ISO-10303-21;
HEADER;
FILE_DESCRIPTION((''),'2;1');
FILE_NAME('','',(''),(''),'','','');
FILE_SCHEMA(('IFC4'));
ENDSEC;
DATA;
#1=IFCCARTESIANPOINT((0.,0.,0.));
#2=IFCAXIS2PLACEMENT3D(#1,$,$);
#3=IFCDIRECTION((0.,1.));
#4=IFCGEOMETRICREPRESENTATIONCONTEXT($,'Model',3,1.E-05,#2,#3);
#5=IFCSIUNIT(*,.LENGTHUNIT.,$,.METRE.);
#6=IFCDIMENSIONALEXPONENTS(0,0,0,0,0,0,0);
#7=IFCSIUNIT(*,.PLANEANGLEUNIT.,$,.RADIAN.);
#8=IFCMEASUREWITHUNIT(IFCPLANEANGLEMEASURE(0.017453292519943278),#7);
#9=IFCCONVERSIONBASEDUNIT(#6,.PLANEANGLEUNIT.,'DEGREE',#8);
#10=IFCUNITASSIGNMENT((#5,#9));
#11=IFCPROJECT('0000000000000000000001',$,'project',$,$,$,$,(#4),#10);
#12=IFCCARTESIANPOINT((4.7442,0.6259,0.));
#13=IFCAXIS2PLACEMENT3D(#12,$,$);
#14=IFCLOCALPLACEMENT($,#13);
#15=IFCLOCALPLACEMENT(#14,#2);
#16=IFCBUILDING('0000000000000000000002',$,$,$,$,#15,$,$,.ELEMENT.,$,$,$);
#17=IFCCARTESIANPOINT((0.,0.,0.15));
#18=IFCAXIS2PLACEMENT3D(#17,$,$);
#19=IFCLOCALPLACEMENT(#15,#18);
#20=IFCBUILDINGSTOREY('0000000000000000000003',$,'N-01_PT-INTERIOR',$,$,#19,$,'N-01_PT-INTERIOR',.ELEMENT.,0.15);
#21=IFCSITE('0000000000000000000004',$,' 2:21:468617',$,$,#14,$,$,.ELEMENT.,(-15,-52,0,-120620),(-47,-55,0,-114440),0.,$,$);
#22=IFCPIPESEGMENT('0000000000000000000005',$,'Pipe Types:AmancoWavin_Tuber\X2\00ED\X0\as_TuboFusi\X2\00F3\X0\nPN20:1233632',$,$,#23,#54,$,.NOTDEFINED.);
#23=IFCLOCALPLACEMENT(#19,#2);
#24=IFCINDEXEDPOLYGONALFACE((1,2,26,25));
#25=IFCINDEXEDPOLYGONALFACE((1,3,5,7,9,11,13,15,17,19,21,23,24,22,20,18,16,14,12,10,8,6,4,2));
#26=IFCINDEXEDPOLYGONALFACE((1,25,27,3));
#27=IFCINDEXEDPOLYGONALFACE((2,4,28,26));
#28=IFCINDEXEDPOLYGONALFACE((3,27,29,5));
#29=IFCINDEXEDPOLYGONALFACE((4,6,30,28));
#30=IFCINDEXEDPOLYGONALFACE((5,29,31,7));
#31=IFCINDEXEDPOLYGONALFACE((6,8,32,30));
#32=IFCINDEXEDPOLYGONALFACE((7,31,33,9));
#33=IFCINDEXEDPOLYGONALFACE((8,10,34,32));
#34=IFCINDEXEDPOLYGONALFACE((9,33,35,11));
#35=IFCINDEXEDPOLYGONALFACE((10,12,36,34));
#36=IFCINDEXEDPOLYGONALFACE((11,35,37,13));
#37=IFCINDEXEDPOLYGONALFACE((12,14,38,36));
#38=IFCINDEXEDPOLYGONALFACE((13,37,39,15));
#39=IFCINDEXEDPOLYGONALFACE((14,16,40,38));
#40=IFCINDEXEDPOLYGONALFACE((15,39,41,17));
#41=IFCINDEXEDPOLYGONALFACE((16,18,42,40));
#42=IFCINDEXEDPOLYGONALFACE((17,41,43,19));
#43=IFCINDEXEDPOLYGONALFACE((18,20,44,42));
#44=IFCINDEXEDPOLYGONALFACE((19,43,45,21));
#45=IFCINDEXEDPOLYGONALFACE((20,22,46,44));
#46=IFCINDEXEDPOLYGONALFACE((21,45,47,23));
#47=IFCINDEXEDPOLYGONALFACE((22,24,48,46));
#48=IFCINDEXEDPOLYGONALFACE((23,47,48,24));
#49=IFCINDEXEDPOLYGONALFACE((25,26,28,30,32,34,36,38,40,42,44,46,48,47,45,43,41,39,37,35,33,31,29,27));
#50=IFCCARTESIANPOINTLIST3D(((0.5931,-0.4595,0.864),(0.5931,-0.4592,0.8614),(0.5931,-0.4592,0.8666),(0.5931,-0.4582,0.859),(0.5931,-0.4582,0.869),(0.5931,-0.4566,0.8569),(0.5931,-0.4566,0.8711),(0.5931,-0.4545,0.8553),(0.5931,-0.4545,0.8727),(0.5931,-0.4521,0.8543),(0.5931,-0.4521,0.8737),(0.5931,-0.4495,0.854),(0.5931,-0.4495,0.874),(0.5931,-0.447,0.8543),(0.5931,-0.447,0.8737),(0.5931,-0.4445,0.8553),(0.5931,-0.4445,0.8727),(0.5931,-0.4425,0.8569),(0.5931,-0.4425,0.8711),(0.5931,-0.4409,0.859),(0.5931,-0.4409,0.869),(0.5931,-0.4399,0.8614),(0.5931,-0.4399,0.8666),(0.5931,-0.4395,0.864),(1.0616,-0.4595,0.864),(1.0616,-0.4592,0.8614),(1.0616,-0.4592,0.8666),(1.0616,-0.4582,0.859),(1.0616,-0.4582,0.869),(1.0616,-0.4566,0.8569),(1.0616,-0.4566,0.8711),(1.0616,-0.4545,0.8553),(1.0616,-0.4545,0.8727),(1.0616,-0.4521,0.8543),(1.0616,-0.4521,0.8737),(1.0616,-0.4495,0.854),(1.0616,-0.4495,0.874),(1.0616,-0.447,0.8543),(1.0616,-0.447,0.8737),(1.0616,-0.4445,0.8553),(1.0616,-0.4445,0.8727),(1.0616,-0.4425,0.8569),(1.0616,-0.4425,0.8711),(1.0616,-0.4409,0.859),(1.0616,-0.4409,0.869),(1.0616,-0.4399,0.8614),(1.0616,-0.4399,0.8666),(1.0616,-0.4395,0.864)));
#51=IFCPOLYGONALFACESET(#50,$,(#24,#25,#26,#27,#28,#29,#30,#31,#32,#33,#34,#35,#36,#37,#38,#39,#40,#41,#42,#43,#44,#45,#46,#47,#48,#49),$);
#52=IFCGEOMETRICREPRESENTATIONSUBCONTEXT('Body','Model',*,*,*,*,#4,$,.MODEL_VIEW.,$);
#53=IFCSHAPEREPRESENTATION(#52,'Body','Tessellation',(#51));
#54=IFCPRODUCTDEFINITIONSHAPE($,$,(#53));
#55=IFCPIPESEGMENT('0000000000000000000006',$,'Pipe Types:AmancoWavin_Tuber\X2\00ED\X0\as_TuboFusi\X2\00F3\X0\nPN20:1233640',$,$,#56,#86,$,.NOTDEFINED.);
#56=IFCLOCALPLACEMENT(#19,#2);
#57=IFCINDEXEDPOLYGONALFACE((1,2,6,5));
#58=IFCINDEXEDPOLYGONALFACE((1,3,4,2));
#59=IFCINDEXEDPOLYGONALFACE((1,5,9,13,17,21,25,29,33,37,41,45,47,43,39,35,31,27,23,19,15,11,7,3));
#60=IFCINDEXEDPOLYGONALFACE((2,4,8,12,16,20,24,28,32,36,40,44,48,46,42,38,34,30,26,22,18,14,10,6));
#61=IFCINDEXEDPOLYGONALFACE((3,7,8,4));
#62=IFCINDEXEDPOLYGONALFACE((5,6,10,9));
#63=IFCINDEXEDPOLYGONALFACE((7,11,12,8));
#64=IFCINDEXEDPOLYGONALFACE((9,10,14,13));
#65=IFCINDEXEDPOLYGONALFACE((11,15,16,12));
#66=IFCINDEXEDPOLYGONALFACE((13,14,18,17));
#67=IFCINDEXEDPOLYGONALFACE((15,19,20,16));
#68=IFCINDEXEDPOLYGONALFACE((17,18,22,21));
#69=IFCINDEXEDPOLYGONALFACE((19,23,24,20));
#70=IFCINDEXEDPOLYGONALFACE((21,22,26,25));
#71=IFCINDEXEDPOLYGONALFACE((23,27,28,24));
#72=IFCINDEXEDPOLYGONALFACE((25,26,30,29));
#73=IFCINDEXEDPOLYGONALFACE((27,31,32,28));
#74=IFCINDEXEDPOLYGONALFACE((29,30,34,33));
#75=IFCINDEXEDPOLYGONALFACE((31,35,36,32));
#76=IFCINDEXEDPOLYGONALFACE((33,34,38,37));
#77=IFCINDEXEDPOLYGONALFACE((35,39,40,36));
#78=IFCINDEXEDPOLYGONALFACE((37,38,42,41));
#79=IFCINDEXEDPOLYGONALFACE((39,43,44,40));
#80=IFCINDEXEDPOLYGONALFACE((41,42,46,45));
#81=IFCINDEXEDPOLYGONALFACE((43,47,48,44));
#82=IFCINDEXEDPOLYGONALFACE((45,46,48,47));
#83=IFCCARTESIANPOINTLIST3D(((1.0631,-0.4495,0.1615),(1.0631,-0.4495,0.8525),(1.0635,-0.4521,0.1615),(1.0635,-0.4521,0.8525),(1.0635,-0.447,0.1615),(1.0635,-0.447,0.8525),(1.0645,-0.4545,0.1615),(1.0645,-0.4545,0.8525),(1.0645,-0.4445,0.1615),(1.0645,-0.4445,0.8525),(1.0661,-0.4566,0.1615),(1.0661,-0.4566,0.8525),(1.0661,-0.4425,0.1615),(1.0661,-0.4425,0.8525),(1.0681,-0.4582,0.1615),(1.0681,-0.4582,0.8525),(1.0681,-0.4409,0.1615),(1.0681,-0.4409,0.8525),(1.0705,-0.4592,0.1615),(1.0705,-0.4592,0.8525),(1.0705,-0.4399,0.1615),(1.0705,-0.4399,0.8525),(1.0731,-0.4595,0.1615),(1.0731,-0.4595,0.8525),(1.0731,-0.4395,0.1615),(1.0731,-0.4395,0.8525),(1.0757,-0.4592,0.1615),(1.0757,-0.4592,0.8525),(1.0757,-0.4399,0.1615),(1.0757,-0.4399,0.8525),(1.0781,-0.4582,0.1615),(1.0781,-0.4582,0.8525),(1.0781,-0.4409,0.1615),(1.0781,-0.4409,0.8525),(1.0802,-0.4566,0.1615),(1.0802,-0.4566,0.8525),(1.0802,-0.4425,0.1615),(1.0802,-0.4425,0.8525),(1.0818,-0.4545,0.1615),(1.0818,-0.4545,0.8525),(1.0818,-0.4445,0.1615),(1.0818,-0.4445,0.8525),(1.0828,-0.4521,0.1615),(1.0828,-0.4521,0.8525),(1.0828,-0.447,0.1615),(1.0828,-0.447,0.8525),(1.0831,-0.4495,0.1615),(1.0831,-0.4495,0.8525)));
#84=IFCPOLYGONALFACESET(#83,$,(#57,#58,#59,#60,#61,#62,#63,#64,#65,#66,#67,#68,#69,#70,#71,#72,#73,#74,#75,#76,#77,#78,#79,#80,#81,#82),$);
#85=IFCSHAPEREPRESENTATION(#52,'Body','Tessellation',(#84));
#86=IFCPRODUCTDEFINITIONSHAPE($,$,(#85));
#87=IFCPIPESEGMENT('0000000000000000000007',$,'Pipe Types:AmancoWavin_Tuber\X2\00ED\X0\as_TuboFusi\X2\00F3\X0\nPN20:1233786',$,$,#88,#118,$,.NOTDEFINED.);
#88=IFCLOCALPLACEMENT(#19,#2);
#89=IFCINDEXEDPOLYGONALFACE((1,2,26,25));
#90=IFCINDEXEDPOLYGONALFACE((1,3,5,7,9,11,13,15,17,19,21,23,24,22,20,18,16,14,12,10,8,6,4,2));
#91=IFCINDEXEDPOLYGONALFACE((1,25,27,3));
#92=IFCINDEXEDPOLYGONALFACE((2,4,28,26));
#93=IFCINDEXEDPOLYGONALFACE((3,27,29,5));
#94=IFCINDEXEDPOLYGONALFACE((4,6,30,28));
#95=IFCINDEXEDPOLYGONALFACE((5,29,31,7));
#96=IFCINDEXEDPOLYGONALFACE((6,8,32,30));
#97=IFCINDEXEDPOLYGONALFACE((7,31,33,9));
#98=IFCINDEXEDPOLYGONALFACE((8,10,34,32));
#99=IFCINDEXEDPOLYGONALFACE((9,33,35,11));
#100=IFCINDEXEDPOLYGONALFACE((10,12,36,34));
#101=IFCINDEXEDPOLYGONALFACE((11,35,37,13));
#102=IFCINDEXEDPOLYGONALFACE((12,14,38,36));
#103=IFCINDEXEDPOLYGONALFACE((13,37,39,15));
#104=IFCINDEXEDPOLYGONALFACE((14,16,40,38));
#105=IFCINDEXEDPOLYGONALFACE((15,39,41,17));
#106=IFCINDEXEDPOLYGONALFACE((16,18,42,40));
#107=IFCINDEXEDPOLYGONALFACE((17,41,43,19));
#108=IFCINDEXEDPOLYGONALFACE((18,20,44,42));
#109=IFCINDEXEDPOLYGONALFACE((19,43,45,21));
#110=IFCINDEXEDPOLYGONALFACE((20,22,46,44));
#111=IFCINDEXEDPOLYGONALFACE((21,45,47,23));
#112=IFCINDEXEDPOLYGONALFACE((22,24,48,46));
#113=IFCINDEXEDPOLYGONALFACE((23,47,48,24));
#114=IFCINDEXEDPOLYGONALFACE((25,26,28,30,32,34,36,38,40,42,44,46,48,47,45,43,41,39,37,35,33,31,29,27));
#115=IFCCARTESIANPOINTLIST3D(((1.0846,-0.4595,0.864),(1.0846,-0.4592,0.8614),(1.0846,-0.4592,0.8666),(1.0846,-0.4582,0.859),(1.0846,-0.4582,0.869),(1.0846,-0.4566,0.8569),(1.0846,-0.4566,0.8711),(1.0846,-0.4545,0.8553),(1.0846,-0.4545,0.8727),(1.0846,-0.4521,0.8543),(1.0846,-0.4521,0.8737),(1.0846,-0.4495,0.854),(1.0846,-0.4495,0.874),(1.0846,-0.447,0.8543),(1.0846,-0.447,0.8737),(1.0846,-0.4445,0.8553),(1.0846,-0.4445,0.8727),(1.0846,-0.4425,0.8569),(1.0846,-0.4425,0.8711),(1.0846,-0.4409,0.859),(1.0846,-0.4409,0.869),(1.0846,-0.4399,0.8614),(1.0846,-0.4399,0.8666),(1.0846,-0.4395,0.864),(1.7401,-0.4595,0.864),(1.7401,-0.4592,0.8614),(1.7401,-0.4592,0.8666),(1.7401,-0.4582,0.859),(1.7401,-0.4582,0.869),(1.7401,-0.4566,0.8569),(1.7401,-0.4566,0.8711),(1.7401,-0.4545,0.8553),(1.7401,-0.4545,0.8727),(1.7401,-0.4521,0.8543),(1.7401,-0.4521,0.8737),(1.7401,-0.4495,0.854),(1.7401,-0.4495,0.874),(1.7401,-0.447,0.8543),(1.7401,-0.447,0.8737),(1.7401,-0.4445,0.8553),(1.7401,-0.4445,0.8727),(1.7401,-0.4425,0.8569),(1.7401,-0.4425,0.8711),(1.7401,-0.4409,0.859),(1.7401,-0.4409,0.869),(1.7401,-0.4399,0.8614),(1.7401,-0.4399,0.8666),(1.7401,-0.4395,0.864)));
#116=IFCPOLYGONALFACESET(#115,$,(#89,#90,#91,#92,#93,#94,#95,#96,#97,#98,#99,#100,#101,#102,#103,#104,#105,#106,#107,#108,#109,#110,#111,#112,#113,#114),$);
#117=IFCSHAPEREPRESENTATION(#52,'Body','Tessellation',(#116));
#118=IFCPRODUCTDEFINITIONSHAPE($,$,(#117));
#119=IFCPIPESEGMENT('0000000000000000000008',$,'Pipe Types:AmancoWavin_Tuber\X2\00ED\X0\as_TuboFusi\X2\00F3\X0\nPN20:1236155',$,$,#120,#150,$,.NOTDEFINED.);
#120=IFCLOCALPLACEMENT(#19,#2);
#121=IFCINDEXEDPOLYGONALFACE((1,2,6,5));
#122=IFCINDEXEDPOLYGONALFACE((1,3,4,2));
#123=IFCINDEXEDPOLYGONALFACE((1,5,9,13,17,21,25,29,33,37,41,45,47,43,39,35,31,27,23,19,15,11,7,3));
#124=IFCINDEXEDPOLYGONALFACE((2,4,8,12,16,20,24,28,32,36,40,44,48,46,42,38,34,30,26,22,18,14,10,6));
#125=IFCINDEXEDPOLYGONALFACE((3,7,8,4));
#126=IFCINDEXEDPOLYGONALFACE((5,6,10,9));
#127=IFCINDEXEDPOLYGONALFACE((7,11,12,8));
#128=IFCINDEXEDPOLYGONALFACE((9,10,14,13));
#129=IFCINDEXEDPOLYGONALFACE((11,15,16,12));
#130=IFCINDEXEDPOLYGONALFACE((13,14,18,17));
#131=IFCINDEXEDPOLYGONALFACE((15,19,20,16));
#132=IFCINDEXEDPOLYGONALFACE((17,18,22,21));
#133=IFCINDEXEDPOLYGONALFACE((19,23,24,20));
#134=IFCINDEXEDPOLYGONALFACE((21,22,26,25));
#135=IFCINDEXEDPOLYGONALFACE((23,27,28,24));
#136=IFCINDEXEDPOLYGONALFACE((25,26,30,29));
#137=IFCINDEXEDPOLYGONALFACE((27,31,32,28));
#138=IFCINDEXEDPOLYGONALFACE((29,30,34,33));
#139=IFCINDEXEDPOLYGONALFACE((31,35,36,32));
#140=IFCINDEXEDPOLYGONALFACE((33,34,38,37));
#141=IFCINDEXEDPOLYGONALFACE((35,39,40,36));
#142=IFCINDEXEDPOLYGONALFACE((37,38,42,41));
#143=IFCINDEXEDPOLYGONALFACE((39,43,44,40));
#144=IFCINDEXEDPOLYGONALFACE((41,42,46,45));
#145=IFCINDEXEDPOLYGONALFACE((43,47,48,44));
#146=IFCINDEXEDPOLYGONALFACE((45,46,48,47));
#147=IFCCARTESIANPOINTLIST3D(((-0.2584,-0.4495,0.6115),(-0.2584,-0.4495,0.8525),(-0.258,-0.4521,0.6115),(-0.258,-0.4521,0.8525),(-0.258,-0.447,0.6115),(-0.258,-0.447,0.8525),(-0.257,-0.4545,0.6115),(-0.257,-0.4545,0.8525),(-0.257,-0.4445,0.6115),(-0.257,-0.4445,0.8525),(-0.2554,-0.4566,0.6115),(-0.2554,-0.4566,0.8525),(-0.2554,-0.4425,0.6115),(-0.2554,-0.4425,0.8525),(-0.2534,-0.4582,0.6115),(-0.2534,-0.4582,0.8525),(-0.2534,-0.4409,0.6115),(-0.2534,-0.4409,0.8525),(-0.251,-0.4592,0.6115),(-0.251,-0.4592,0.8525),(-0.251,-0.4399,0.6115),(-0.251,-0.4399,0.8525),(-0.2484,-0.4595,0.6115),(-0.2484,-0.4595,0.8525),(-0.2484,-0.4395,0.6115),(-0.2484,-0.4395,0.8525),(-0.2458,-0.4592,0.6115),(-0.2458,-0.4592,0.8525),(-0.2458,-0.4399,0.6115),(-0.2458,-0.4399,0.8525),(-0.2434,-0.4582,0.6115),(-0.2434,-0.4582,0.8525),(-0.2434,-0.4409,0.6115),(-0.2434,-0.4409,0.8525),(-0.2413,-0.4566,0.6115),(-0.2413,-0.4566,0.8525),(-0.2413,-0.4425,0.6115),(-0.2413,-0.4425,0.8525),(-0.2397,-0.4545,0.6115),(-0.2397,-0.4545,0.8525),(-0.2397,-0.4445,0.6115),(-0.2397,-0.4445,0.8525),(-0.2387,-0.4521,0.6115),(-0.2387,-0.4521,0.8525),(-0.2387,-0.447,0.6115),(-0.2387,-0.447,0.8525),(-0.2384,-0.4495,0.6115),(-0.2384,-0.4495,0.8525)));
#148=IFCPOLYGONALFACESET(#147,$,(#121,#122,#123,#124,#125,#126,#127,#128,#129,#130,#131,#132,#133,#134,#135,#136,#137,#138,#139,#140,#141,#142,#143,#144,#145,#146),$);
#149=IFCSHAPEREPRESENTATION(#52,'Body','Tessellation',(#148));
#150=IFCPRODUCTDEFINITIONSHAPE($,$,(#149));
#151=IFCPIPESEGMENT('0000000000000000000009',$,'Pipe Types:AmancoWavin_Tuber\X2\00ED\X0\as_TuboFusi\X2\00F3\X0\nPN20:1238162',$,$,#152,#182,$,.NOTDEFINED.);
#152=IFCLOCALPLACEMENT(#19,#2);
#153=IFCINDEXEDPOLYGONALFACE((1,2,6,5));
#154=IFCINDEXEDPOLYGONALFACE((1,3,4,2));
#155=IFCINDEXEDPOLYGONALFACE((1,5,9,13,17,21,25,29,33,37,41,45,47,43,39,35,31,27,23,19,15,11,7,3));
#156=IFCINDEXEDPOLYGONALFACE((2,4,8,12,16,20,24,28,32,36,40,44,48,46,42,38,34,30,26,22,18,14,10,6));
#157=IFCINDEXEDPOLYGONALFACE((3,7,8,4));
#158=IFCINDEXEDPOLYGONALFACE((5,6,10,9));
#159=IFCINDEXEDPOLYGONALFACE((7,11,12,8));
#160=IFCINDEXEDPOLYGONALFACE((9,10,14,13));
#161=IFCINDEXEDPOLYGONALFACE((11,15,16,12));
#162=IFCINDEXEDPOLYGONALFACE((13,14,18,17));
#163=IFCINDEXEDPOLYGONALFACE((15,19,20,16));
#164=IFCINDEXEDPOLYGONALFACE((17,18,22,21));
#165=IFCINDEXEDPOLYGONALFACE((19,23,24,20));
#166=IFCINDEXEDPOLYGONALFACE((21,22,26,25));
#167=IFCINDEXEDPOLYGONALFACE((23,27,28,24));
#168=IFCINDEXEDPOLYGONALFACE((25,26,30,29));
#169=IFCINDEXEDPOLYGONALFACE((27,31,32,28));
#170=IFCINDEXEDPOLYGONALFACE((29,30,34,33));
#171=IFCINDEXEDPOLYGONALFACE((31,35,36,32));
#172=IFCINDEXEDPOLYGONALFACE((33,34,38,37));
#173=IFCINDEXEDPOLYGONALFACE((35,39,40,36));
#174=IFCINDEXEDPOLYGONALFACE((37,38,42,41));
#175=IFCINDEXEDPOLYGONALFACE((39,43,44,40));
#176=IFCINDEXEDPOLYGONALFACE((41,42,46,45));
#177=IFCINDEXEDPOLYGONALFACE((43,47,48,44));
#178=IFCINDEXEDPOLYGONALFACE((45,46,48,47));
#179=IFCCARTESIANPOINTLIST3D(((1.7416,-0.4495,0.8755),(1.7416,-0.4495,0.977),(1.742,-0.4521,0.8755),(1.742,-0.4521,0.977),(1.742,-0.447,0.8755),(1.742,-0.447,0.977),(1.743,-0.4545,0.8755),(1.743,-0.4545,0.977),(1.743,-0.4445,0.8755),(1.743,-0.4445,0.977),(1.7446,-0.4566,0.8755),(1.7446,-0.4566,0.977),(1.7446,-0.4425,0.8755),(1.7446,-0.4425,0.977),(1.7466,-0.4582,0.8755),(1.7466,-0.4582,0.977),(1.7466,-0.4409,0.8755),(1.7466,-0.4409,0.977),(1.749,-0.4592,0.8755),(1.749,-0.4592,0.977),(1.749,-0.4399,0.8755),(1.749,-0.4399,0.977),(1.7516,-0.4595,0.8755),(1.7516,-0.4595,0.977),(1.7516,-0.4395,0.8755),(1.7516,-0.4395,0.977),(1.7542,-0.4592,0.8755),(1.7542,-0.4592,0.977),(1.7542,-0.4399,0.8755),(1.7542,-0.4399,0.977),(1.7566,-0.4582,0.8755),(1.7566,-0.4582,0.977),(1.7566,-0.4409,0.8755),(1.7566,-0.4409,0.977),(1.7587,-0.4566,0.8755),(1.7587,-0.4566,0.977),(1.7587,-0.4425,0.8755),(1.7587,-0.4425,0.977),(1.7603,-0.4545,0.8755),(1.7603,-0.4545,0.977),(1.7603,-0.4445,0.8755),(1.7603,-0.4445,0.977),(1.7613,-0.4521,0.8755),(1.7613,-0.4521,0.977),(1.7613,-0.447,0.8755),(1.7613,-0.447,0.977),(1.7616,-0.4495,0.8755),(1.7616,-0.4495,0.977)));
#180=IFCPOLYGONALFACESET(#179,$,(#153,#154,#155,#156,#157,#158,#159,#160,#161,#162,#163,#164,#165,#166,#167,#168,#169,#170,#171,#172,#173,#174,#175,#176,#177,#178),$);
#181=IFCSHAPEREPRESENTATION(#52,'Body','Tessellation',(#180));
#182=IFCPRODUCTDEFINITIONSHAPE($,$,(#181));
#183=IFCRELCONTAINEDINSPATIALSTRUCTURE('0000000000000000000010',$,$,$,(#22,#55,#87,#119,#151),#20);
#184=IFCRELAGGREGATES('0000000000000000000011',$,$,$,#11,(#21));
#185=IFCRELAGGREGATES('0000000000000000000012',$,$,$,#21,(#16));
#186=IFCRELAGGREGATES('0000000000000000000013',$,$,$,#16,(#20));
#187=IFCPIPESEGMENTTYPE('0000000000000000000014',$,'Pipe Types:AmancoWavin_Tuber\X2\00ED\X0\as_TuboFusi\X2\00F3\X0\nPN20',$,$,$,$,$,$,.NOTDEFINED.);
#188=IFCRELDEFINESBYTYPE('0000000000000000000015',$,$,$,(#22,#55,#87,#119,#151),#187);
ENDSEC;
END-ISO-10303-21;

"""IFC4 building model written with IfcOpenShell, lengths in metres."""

from ifc_helpers import new_model, entity, si_unit, converted_unit, direction, frame, origin, place, context, subcontext, project, spatial, arc, indexed_curve, outline, extrude, type_object, element, save


model = new_model("IFC4")

# Units and contexts
model_context = context("Model", 3, precision=1e-05, world=origin(), true_north=direction((0.0, 1.0)))
body_context = subcontext(model_context, "Body", "Model", "MODEL_VIEW")
ifc_project = project(units=[si_unit("LENGTHUNIT", "METRE"), converted_unit("PLANEANGLEUNIT", "DEGREE", entity("IfcPlaneAngleMeasure", 0.017453292519943278), si_unit("PLANEANGLEUNIT", "RADIAN"), dimensions=[0, 0, 0, 0, 0, 0, 0])], contexts=[model_context])

# Site, building, storey
site_placement = place(None, frame((4.7442, 0.6259, 0.0)))
site = spatial("IfcSite", under=ifc_project, at=site_placement, Name=" 2:21:468617", CompositionType="ELEMENT", RefLatitude=(-15, -52, 0, -120620), RefLongitude=(-47, -55, 0, -114440), RefElevation=0.0)
building_placement = place(site_placement, origin())
building = spatial("IfcBuilding", under=site, at=building_placement, CompositionType="ELEMENT")
storey_placement = place(building_placement, frame((0.0, 0.0, 0.15)))
storey = spatial("IfcBuildingStorey", under=building, at=storey_placement, Name="N-01_PT-INTERIOR", LongName="N-01_PT-INTERIOR", CompositionType="ELEMENT", Elevation=0.15)

# Pipe segments
pipe_segment_type_1 = type_object("IfcPipeSegmentType", Name="Pipe Types:AmancoWavin_Tuberías_TuboFusiónPN20", PredefinedType="NOTDEFINED")
pipe_segment_1_placement = place(storey_placement, origin())
element("IfcPipeSegment", 1, at=pipe_segment_1_placement, inside=storey, type_object=pipe_segment_type_1, Name="Pipe Types:AmancoWavin_Tuberías_TuboFusiónPN20:1233632", PredefinedType="NOTDEFINED", context=body_context, shape_type="SweptSolid", body=[
    extrude(outline(indexed_curve([(0.01, 0.0), (0.0071, 0.0071), (0.0, 0.01), (-0.0071, 0.0071), (-0.01, 0.0), (-0.0071, -0.0071), (0.0, -0.01), (0.0071, -0.0071)], segments=[arc(1, 2, 3), arc(3, 4, 5), arc(5, 6, 7), arc(7, 8, 1)], self_intersect=False)), frame((0.5931, -0.4495, 0.864), z_axis=(1.0, 0.0, 0.0), x_axis=(0.0, -1.0, 0.0)), (0.0, 0.0, 1.0), 0.4685),
])
pipe_segment_2_placement = place(storey_placement, origin())
element("IfcPipeSegment", 2, at=pipe_segment_2_placement, inside=storey, type_object=pipe_segment_type_1, Name="Pipe Types:AmancoWavin_Tuberías_TuboFusiónPN20:1233640", PredefinedType="NOTDEFINED", context=body_context, shape_type="SweptSolid", body=[
    extrude(outline(indexed_curve([(0.01, 0.0), (0.0071, 0.0071), (0.0, 0.01), (-0.0071, 0.0071), (-0.01, 0.0), (-0.0071, -0.0071), (0.0, -0.01), (0.0071, -0.0071)], segments=[arc(1, 2, 3), arc(3, 4, 5), arc(5, 6, 7), arc(7, 8, 1)], self_intersect=False)), frame((1.0731, -0.4495, 0.1615)), (0.0, 0.0, 1.0), 0.691),
])
pipe_segment_3_placement = place(storey_placement, origin())
element("IfcPipeSegment", 3, at=pipe_segment_3_placement, inside=storey, type_object=pipe_segment_type_1, Name="Pipe Types:AmancoWavin_Tuberías_TuboFusiónPN20:1233786", PredefinedType="NOTDEFINED", context=body_context, shape_type="SweptSolid", body=[
    extrude(outline(indexed_curve([(0.01, 0.0), (0.0071, 0.0071), (0.0, 0.01), (-0.0071, 0.0071), (-0.01, 0.0), (-0.0071, -0.0071), (0.0, -0.01), (0.0071, -0.0071)], segments=[arc(1, 2, 3), arc(3, 4, 5), arc(5, 6, 7), arc(7, 8, 1)], self_intersect=False)), frame((1.0846, -0.4495, 0.864), z_axis=(1.0, 0.0, 0.0), x_axis=(0.0, -1.0, 0.0)), (0.0, 0.0, 1.0), 0.6555),
])
pipe_segment_4_placement = place(storey_placement, origin())
element("IfcPipeSegment", 4, at=pipe_segment_4_placement, inside=storey, type_object=pipe_segment_type_1, Name="Pipe Types:AmancoWavin_Tuberías_TuboFusiónPN20:1236155", PredefinedType="NOTDEFINED", context=body_context, shape_type="SweptSolid", body=[
    extrude(outline(indexed_curve([(0.01, 0.0), (0.0071, 0.0071), (0.0, 0.01), (-0.0071, 0.0071), (-0.01, 0.0), (-0.0071, -0.0071), (0.0, -0.01), (0.0071, -0.0071)], segments=[arc(1, 2, 3), arc(3, 4, 5), arc(5, 6, 7), arc(7, 8, 1)], self_intersect=False)), frame((-0.2484, -0.4495, 0.6115)), (0.0, 0.0, 1.0), 0.241),
])
pipe_segment_5_placement = place(storey_placement, origin())
element("IfcPipeSegment", 5, at=pipe_segment_5_placement, inside=storey, type_object=pipe_segment_type_1, Name="Pipe Types:AmancoWavin_Tuberías_TuboFusiónPN20:1238162", PredefinedType="NOTDEFINED", context=body_context, shape_type="SweptSolid", body=[
    extrude(outline(indexed_curve([(0.01, 0.0), (0.0071, 0.0071), (0.0, 0.01), (-0.0071, 0.0071), (-0.01, 0.0), (-0.0071, -0.0071), (0.0, -0.01), (0.0071, -0.0071)], segments=[arc(1, 2, 3), arc(3, 4, 5), arc(5, 6, 7), arc(7, 8, 1)], self_intersect=False)), frame((1.7516, -0.4495, 0.8755), z_axis=(0.0, 0.0, 1.0), x_axis=(-1.0, 0.0, 0.0)), (0.0, 0.0, 1.0), 0.1015),
])

save(model, "model.ifc")
